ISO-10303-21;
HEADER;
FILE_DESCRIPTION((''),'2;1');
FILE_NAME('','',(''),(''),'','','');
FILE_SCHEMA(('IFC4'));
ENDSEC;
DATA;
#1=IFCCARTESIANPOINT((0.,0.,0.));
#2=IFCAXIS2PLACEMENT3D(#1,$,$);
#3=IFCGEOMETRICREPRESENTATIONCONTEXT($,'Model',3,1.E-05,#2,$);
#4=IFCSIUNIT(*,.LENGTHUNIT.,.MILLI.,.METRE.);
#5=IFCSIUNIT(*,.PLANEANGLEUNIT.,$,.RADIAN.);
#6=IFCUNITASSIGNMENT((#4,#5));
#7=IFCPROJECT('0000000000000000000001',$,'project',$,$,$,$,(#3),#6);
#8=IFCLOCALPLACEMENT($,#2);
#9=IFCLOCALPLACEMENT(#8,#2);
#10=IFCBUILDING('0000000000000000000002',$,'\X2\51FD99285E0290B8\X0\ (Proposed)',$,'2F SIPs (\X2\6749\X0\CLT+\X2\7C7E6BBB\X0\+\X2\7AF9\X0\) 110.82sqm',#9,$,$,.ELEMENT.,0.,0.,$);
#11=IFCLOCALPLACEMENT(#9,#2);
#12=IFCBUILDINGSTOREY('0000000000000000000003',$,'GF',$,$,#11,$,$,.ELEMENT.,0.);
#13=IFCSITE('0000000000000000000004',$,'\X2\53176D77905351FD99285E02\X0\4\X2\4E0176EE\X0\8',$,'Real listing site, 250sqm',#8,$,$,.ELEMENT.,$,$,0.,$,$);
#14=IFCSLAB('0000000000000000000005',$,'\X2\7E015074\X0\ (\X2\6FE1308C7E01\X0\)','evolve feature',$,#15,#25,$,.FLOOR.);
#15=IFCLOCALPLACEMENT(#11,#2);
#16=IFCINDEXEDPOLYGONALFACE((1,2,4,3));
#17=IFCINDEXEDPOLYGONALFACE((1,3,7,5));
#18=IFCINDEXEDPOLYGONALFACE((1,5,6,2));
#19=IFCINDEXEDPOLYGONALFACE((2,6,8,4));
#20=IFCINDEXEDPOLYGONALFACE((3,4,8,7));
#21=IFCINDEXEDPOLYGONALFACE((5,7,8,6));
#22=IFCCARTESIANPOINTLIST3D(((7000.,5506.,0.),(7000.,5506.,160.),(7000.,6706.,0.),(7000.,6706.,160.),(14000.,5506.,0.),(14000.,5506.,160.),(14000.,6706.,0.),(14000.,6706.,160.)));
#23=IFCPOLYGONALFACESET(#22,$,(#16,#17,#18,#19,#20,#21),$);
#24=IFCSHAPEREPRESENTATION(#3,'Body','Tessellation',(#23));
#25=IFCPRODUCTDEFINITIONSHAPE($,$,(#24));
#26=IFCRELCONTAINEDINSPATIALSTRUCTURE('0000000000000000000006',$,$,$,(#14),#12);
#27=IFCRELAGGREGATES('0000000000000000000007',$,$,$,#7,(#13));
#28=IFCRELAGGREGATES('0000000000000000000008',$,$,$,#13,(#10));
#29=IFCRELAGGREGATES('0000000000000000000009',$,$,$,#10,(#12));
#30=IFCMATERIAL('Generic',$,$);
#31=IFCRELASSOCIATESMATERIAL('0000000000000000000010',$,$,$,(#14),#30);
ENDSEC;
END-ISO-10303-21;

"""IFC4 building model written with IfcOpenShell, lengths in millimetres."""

from ifc_helpers import new_model, si_unit, frame, frame_2d, origin, place, context, project, spatial, rectangle, extrude, material, element, save


model = new_model("IFC4")

# Units and contexts
model_context = context("Model", 3, precision=1e-05, world=origin())
ifc_project = project(units=[si_unit("LENGTHUNIT", "METRE", prefix="MILLI"), si_unit("PLANEANGLEUNIT", "RADIAN")], contexts=[model_context])

# Site, building, storey
site_placement = place(None, origin())
site = spatial("IfcSite", under=ifc_project, at=site_placement, Name="北海道函館市4丁目8", ObjectType="Real listing site, 250sqm", CompositionType="ELEMENT", RefElevation=0.0)
building_placement = place(site_placement, origin())
building = spatial("IfcBuilding", under=site, at=building_placement, Name="函館市邸 (Proposed)", ObjectType="2F SIPs (杉CLT+籾殻+竹) 110.82sqm", CompositionType="ELEMENT", ElevationOfRefHeight=0.0, ElevationOfTerrain=0.0)
storey_placement = place(building_placement, origin())
storey = spatial("IfcBuildingStorey", under=building, at=storey_placement, Name="GF", CompositionType="ELEMENT", Elevation=0.0)

# Slab
ifc_material_1 = material(Name="Generic")
slab_1_placement = place(storey_placement, frame((3500.0, 2753.0, 0.0)))
element("IfcSlab", 1, at=slab_1_placement, inside=storey, material=ifc_material_1, Name="縁側 (濡れ縁)", Description="evolve feature", PredefinedType="FLOOR", context=model_context, shape_type="SweptSolid", body=[
    extrude(rectangle(XDim=7000.0, YDim=1200.0, at=frame_2d((3500.0, 600.0))), frame((3500.0, 2753.0, 0.0)), (0.0, 0.0, 1.0), 160.0),
])

save(model, "model.ifc")
